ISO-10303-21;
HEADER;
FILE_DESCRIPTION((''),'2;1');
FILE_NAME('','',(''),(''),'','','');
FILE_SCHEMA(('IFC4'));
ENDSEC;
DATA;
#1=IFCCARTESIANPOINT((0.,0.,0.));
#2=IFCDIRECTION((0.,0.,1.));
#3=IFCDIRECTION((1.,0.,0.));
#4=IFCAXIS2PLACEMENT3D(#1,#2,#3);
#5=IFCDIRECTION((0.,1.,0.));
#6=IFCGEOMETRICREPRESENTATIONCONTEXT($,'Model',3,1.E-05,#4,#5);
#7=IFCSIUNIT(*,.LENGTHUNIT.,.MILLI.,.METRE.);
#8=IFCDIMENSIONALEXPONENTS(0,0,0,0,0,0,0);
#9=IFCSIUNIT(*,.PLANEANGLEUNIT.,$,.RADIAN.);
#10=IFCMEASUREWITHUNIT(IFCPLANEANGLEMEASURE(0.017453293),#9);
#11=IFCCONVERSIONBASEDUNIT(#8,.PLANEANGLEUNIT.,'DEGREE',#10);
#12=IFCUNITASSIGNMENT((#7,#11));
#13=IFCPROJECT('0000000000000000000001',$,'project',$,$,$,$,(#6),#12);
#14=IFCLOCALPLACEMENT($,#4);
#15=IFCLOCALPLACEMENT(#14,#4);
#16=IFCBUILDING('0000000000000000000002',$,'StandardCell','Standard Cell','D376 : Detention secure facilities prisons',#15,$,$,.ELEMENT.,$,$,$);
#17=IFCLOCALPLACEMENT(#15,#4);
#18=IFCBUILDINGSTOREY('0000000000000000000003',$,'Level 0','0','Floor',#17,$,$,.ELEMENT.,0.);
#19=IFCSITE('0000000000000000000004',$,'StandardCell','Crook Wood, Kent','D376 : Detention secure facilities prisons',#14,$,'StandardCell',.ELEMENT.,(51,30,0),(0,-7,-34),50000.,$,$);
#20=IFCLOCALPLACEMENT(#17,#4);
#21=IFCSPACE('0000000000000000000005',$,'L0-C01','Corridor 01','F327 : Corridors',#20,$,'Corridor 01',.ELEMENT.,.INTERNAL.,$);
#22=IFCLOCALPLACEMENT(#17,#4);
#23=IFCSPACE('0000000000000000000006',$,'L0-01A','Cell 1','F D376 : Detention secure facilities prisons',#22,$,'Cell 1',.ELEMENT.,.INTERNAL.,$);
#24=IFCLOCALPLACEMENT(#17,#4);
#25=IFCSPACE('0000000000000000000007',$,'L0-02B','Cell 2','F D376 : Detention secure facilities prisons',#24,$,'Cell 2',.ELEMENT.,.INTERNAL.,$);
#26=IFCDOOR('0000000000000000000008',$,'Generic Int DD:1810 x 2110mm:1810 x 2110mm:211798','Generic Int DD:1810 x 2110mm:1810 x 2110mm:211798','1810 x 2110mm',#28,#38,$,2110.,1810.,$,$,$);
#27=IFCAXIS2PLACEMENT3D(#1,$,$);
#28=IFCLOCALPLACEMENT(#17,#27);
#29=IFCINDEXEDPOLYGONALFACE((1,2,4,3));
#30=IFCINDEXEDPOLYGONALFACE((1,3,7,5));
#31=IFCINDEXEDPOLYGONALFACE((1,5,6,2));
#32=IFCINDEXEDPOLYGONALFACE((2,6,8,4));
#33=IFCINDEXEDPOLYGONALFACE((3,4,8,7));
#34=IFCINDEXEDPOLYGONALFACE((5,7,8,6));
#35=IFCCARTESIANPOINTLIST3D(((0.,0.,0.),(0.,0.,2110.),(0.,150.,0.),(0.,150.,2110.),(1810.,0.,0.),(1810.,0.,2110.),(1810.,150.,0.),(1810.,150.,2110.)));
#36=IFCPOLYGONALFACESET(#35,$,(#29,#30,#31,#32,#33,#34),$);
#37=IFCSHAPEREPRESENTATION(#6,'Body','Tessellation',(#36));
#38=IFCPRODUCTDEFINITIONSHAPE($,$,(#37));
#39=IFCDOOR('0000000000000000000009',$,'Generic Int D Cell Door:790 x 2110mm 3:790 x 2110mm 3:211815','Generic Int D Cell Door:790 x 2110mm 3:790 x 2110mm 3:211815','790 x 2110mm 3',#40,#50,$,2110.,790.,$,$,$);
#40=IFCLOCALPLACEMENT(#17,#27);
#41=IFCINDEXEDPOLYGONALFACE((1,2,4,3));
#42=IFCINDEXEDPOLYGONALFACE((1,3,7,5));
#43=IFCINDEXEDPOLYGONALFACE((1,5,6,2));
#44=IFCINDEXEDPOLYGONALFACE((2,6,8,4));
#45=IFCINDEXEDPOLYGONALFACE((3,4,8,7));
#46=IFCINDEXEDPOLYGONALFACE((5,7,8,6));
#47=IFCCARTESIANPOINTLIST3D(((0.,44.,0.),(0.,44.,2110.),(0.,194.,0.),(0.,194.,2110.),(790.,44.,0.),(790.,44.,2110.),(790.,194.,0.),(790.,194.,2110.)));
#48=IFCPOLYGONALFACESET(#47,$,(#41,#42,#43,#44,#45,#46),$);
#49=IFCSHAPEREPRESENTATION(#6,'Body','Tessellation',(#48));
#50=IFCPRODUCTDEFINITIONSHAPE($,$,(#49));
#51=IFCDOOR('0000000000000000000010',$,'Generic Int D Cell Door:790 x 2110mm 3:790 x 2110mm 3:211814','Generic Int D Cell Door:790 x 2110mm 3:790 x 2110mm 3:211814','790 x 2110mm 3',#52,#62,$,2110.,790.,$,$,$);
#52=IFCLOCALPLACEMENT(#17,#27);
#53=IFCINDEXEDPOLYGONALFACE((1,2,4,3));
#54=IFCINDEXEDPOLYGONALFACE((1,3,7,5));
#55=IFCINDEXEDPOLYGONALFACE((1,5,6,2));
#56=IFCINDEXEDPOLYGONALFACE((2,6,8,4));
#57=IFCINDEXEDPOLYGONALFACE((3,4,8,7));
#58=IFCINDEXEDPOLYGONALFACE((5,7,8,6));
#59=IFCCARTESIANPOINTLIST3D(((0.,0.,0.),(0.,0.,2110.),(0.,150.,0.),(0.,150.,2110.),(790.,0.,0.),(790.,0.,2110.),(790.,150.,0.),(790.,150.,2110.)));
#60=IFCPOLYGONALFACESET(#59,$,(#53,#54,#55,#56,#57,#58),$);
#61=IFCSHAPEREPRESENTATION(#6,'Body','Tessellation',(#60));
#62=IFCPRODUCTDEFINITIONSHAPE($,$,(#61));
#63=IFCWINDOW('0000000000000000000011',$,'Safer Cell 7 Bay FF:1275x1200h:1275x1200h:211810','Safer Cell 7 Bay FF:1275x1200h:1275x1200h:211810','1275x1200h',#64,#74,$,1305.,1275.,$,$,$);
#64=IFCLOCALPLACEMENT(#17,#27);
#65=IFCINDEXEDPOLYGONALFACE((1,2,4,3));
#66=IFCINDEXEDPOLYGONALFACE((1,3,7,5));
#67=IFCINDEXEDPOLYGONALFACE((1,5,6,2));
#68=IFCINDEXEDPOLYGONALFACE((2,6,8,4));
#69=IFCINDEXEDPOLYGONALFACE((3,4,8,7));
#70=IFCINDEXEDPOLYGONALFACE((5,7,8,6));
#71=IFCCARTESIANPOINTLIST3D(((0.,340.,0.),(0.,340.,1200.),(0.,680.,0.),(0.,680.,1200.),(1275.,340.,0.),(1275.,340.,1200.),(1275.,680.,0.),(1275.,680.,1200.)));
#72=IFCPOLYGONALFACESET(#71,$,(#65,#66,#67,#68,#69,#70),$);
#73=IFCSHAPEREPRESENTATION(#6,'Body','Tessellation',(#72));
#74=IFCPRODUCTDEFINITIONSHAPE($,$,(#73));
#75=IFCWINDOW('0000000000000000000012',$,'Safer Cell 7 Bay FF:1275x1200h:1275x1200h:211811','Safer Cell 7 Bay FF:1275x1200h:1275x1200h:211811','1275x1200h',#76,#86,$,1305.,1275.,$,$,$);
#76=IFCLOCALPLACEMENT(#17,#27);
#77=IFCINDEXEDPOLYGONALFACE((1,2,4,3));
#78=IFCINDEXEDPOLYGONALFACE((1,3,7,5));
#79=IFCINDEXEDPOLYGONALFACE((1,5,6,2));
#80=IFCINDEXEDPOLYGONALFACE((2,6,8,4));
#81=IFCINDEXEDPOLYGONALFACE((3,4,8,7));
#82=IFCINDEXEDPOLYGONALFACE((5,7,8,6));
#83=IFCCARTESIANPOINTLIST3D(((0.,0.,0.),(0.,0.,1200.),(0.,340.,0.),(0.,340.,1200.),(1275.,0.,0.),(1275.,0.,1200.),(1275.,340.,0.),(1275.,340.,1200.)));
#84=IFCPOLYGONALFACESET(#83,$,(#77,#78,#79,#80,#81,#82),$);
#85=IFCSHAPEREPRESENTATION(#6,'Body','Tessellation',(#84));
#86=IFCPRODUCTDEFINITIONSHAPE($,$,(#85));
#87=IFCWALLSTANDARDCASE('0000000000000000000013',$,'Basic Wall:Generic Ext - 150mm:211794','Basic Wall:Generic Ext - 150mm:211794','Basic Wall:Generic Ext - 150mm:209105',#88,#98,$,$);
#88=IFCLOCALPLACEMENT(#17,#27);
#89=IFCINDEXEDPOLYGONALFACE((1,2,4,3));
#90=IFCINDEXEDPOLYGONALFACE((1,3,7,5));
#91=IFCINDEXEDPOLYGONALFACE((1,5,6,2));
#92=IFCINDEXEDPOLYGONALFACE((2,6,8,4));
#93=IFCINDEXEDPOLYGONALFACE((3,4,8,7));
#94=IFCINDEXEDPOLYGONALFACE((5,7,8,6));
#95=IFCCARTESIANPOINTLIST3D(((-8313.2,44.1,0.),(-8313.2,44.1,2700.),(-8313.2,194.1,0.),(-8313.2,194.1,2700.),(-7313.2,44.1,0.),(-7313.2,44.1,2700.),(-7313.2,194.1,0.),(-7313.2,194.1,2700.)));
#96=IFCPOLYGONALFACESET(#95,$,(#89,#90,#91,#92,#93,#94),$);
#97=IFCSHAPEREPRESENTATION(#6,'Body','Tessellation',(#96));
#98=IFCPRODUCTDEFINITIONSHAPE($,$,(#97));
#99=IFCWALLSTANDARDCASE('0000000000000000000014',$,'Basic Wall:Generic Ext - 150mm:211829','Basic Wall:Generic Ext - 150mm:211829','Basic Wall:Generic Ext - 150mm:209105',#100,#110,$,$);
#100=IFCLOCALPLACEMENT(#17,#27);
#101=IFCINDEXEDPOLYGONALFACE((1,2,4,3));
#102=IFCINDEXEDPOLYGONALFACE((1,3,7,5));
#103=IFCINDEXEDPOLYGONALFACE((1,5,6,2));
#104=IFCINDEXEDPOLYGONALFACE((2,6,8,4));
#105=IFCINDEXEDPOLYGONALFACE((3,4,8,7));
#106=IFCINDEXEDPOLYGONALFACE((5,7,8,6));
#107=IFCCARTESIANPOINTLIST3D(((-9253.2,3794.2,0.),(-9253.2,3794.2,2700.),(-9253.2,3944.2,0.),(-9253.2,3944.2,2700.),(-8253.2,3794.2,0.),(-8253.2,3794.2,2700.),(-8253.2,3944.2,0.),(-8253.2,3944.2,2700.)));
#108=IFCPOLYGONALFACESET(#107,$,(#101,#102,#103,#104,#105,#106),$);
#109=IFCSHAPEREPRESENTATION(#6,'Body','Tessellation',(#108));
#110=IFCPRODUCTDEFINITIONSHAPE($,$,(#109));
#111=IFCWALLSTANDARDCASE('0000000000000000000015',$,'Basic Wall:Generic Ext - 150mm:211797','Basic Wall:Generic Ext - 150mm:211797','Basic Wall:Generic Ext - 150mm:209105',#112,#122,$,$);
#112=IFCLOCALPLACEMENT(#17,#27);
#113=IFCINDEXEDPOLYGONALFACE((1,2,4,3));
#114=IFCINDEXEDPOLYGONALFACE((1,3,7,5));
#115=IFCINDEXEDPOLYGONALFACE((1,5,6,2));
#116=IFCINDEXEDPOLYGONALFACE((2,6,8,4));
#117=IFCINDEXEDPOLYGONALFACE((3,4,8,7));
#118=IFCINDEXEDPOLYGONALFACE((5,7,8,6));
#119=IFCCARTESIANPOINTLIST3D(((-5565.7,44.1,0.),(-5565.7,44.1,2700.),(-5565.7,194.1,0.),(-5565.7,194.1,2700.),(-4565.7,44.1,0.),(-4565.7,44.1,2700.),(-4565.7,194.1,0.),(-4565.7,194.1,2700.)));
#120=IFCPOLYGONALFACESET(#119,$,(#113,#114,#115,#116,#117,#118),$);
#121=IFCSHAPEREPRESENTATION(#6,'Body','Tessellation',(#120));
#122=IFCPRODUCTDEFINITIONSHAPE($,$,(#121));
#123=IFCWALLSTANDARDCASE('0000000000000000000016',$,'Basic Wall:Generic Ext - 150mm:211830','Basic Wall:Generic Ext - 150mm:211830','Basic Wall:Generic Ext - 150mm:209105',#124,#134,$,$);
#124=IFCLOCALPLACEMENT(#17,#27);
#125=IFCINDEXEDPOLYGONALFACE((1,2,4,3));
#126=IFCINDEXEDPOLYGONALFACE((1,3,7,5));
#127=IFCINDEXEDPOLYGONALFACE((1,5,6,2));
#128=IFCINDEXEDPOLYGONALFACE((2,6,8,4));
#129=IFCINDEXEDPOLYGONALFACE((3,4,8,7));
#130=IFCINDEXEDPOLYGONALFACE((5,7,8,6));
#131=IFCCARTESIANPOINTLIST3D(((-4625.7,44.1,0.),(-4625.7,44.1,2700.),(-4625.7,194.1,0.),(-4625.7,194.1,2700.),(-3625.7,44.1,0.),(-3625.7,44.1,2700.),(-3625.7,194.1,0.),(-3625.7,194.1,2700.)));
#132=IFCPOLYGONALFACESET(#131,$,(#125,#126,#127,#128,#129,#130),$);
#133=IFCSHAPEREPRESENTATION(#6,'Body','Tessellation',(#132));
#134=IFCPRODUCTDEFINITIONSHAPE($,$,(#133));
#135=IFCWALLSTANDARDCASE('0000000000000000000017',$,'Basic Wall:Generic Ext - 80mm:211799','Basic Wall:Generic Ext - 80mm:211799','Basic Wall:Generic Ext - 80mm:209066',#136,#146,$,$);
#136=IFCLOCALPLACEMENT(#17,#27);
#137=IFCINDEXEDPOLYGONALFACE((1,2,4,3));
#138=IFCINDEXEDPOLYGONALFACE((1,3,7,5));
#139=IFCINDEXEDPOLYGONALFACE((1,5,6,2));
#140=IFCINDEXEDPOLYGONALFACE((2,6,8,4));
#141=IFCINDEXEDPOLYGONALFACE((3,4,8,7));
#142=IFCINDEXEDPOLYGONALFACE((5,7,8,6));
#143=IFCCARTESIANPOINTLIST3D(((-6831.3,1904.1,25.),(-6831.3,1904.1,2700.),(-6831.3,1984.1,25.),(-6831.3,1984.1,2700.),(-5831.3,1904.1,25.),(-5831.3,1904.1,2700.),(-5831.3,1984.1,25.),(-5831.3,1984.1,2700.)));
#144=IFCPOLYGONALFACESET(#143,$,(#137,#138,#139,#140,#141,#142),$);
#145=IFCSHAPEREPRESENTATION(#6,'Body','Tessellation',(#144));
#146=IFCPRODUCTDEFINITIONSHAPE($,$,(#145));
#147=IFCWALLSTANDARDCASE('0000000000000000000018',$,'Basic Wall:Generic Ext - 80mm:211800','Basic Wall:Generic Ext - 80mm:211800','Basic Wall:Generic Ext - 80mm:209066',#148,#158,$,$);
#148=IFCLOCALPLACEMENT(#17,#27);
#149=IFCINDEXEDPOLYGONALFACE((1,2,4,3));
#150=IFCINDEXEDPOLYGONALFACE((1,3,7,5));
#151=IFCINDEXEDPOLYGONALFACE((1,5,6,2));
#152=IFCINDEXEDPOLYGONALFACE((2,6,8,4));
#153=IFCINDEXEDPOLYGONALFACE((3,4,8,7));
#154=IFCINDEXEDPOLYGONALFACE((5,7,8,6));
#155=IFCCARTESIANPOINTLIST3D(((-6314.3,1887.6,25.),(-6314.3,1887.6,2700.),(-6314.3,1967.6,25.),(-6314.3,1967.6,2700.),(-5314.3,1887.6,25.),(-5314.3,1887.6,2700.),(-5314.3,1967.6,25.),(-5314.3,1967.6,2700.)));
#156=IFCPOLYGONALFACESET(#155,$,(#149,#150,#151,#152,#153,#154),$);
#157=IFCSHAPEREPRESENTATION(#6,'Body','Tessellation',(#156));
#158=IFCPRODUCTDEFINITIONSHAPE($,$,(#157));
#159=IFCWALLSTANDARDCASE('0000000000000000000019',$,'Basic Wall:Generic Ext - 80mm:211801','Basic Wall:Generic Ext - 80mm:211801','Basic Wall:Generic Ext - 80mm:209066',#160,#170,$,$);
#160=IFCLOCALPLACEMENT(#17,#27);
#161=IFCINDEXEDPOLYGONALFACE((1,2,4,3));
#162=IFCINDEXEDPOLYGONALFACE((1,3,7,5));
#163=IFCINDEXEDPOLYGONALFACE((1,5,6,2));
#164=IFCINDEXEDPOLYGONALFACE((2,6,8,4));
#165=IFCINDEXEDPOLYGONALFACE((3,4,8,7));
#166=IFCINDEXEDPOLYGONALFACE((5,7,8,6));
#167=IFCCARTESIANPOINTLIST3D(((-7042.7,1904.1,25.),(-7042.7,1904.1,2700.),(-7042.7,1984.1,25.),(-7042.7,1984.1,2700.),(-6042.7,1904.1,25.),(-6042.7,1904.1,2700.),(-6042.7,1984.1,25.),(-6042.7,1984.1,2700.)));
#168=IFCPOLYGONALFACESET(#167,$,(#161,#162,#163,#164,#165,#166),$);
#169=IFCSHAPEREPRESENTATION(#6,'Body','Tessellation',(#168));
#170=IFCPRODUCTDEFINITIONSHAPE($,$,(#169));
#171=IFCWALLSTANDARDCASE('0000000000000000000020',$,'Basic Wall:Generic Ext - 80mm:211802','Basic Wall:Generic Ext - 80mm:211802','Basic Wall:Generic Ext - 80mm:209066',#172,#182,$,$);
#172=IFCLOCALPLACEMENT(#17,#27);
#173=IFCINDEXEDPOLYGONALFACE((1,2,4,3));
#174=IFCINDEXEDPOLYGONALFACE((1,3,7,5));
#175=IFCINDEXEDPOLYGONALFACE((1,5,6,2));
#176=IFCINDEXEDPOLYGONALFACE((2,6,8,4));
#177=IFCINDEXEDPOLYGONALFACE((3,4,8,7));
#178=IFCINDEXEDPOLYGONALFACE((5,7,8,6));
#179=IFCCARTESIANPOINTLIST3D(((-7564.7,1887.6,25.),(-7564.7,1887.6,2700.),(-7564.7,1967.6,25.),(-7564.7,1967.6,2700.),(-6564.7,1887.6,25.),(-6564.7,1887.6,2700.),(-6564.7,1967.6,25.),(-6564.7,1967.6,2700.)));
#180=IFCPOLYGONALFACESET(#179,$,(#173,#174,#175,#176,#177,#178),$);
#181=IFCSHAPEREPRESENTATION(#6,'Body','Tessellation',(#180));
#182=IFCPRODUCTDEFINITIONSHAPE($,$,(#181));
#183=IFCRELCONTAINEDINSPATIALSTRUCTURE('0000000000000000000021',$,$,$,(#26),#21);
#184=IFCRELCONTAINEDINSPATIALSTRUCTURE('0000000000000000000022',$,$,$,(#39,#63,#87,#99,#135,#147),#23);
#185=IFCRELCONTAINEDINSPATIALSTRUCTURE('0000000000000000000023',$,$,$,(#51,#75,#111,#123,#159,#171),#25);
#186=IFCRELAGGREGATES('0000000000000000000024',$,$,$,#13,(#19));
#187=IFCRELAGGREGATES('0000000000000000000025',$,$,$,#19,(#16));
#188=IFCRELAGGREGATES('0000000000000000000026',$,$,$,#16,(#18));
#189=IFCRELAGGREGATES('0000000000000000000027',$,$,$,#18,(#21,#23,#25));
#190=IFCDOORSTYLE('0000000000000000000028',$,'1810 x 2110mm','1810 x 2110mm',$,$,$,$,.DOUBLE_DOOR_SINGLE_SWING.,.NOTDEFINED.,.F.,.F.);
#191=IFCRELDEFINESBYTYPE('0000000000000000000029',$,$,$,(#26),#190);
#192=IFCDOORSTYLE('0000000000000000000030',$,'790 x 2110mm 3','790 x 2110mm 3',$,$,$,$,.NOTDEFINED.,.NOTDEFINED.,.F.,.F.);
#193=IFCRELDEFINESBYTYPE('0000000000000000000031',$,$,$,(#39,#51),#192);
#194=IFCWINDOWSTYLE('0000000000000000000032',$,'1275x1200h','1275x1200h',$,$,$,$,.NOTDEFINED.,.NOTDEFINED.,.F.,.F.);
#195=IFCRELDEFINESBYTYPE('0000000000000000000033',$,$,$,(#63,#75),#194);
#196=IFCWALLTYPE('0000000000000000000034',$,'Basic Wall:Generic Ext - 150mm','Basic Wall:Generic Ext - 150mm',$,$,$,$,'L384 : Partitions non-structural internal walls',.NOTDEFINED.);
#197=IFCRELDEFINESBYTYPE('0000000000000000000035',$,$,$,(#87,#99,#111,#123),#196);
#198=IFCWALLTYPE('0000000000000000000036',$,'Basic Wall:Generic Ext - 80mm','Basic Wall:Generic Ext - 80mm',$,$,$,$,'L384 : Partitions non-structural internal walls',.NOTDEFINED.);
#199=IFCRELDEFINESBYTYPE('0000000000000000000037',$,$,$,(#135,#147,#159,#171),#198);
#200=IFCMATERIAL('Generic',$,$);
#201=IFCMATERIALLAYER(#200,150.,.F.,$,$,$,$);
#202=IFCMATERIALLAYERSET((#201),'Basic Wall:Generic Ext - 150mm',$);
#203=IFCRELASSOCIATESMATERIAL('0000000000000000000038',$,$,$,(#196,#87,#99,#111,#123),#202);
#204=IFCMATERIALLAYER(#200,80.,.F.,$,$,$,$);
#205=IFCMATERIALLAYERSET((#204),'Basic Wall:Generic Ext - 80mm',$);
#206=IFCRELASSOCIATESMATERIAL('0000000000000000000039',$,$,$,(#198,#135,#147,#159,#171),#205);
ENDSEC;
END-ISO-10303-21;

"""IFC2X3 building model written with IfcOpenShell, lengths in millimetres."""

from ifc_helpers import new_model, entity, si_unit, converted_unit, direction, frame, frame_2d, origin, origin_with_axes, place, context, project, spatial, rectangle, extrude, source, transform, mapped, material, layer, layer_set, layer_usage, type_object, type_shapes, element, save


model = new_model("IFC2X3")

# Units and contexts
model_context = context("Model", 3, precision=1e-05, world=origin_with_axes(), true_north=direction((0.0, 1.0, 0.0)))
ifc_project = project(units=[si_unit("LENGTHUNIT", "METRE", prefix="MILLI"), converted_unit("PLANEANGLEUNIT", "DEGREE", entity("IfcPlaneAngleMeasure", 0.017453293), si_unit("PLANEANGLEUNIT", "RADIAN"), dimensions=[0, 0, 0, 0, 0, 0, 0])], contexts=[model_context])

# Site, building, storey, space
site_placement = place(None, origin_with_axes())
site = spatial("IfcSite", under=ifc_project, at=site_placement, Name="StandardCell", Description="Crook Wood, Kent", ObjectType="D376 : Detention secure facilities prisons", LongName="StandardCell", CompositionType="ELEMENT", RefLatitude=(51, 30, 0), RefLongitude=(0, -7, -34), RefElevation=50000.0)
building_placement = place(site_placement, origin_with_axes())
building = spatial("IfcBuilding", under=site, at=building_placement, Name="StandardCell", Description="Standard Cell", ObjectType="D376 : Detention secure facilities prisons", CompositionType="ELEMENT")
storey_placement = place(building_placement, origin_with_axes())
storey = spatial("IfcBuildingStorey", under=building, at=storey_placement, Name="Level 0", Description="0", ObjectType="Floor", CompositionType="ELEMENT", Elevation=0.0)
space_1_placement = place(storey_placement, origin_with_axes())
space_1 = spatial("IfcSpace", under=storey, at=space_1_placement, Name="L0-C01", Description="Corridor 01", ObjectType="F327 : Corridors", LongName="Corridor 01", CompositionType="ELEMENT", InteriorOrExteriorSpace="INTERNAL")

# Door
door_style_1 = type_object("IfcDoorStyle", Name="1810 x 2110mm", Description="1810 x 2110mm", ConstructionType="NOTDEFINED", OperationType="DOUBLE_DOOR_SINGLE_SWING", ParameterTakesPrecedence=False, Sizeable=False)
shared_shape_1 = source(origin(), model_context, "Body", "SweptSolid", [
    extrude(rectangle(XDim=1810.0, YDim=150.0, at=frame_2d((905.0, 75.0), x_axis=(1.0, 0.0))), origin_with_axes(), (0.0, 0.0, 1.0), 2110.0),
])
type_shapes(door_style_1, [shared_shape_1])
door_1_placement = place(space_1_placement, origin_with_axes())
element("IfcDoor", 1, at=door_1_placement, inside=space_1, type_object=door_style_1, Name="Generic Int DD:1810 x 2110mm:1810 x 2110mm:211798", Description="Generic Int DD:1810 x 2110mm:1810 x 2110mm:211798", ObjectType="1810 x 2110mm", OverallHeight=2110.0, OverallWidth=1810.0, context=model_context, shape_type="MappedRepresentation", body=[
    mapped(shared_shape_1, transform((0.0, 0.0, 0.0))),
])

# Shared definitions
space_2_placement = place(storey_placement, origin_with_axes())
space_2 = spatial("IfcSpace", under=storey, at=space_2_placement, Name="L0-01A", Description="Cell 1", ObjectType="F D376 : Detention secure facilities prisons", LongName="Cell 1", CompositionType="ELEMENT", InteriorOrExteriorSpace="INTERNAL")

# Door
door_style_2 = type_object("IfcDoorStyle", Name="790 x 2110mm 3", Description="790 x 2110mm 3", ConstructionType="NOTDEFINED", OperationType="NOTDEFINED", ParameterTakesPrecedence=False, Sizeable=False)
shared_shape_2 = source(origin(), model_context, "Body", "SweptSolid", [
    extrude(rectangle(XDim=790.0, YDim=150.0, at=frame_2d((395.0, 75.0), x_axis=(1.0, 0.0))), origin_with_axes(), (0.0, 0.0, 1.0), 2110.0),
])
type_shapes(door_style_2, [shared_shape_2])
door_2_placement = place(space_2_placement, frame((0.0, 44.0, 0.0), z_axis=(0.0, 0.0, 1.0), x_axis=(1.0, 0.0, 0.0)))
element("IfcDoor", 2, at=door_2_placement, inside=space_2, type_object=door_style_2, Name="Generic Int D Cell Door:790 x 2110mm 3:790 x 2110mm 3:211815", Description="Generic Int D Cell Door:790 x 2110mm 3:790 x 2110mm 3:211815", ObjectType="790 x 2110mm 3", OverallHeight=2110.0, OverallWidth=790.0, context=model_context, shape_type="MappedRepresentation", body=[
    mapped(shared_shape_2, transform((0.0, 0.0, 0.0))),
])

# Shared definitions
space_3_placement = place(storey_placement, origin_with_axes())
space_3 = spatial("IfcSpace", under=storey, at=space_3_placement, Name="L0-02B", Description="Cell 2", ObjectType="F D376 : Detention secure facilities prisons", LongName="Cell 2", CompositionType="ELEMENT", InteriorOrExteriorSpace="INTERNAL")

# Door
door_3_placement = place(space_3_placement, origin_with_axes())
element("IfcDoor", 3, at=door_3_placement, inside=space_3, type_object=door_style_2, Name="Generic Int D Cell Door:790 x 2110mm 3:790 x 2110mm 3:211814", Description="Generic Int D Cell Door:790 x 2110mm 3:790 x 2110mm 3:211814", ObjectType="790 x 2110mm 3", OverallHeight=2110.0, OverallWidth=790.0, context=model_context, shape_type="MappedRepresentation", body=[
    mapped(shared_shape_2, transform((0.0, 0.0, 0.0))),
])

# Windows
window_style = type_object("IfcWindowStyle", Name="1275x1200h", Description="1275x1200h", ConstructionType="NOTDEFINED", OperationType="NOTDEFINED", ParameterTakesPrecedence=False, Sizeable=False)
shared_shape_3 = source(origin(), model_context, "Body", "SweptSolid", [
    extrude(rectangle(XDim=1275.0, YDim=340.0, at=frame_2d((637.5, 170.0), x_axis=(1.0, 0.0))), origin_with_axes(), (0.0, 0.0, 1.0), 1200.0),
])
type_shapes(window_style, [shared_shape_3])
window_1_placement = place(space_2_placement, frame((0.0, 340.0, 0.0), z_axis=(0.0, 0.0, 1.0), x_axis=(1.0, 0.0, 0.0)))
element("IfcWindow", 4, at=window_1_placement, inside=space_2, type_object=window_style, Name="Safer Cell 7 Bay FF:1275x1200h:1275x1200h:211810", Description="Safer Cell 7 Bay FF:1275x1200h:1275x1200h:211810", ObjectType="1275x1200h", OverallHeight=1305.0, OverallWidth=1275.0, context=model_context, shape_type="MappedRepresentation", body=[
    mapped(shared_shape_3, transform((0.0, 0.0, 0.0))),
])
window_2_placement = place(space_3_placement, origin_with_axes())
element("IfcWindow", 5, at=window_2_placement, inside=space_3, type_object=window_style, Name="Safer Cell 7 Bay FF:1275x1200h:1275x1200h:211811", Description="Safer Cell 7 Bay FF:1275x1200h:1275x1200h:211811", ObjectType="1275x1200h", OverallHeight=1305.0, OverallWidth=1275.0, context=model_context, shape_type="MappedRepresentation", body=[
    mapped(shared_shape_3, transform((0.0, 0.0, 0.0))),
])

# Walls
ifc_material = material(Name="Generic")
ifc_layer_1 = layer(ifc_material, 150.0, ventilated=False)
ifc_layer_set_1 = layer_set([ifc_layer_1], Name="Basic Wall:Generic Ext - 150mm")
ifc_layer_usage_1 = layer_usage(ifc_layer_set_1, "AXIS3", "POSITIVE", 0.0)
wall_type_1 = type_object("IfcWallType", Name="Basic Wall:Generic Ext - 150mm", Description="Basic Wall:Generic Ext - 150mm", ElementType="L384 : Partitions non-structural internal walls", PredefinedType="NOTDEFINED", material=ifc_layer_set_1)
shared_shape_4 = source(origin(), model_context, "Body", "SweptSolid", [
    extrude(rectangle(XDim=1000.0, YDim=150.0, at=frame_2d((500.0, 75.0), x_axis=(1.0, 0.0))), origin_with_axes(), (0.0, 0.0, 1.0), 2700.0),
])
type_shapes(wall_type_1, [shared_shape_4])
for number, where, z_axis, x_axis, name, description in (
    (6, (-8313.2, 44.1, 0.0), (0.0, 0.0, 1.0), (1.0, 0.0, 0.0), "Basic Wall:Generic Ext - 150mm:211794", "Basic Wall:Generic Ext - 150mm:211794"),
    (7, (-9253.2, 3794.2, 0.0), (0.0, 0.0, 1.0), (1.0, 0.0, 0.0), "Basic Wall:Generic Ext - 150mm:211829", "Basic Wall:Generic Ext - 150mm:211829"),
):
    element("IfcWallStandardCase", number, at=place(space_2_placement, frame(where, z_axis=z_axis, x_axis=x_axis)), inside=space_2, type_object=wall_type_1, material=ifc_layer_usage_1, Name=name, Description=description, ObjectType="Basic Wall:Generic Ext - 150mm:209105", context=model_context, shape_type="MappedRepresentation", body=[
        mapped(shared_shape_4, transform((0.0, 0.0, 0.0))),
    ])
for number, where, z_axis, x_axis, name, description in (
    (8, (-5565.7, 44.1, 0.0), (0.0, 0.0, 1.0), (1.0, 0.0, 0.0), "Basic Wall:Generic Ext - 150mm:211797", "Basic Wall:Generic Ext - 150mm:211797"),
    (9, (-4625.7, 44.1, 0.0), (0.0, 0.0, 1.0), (1.0, 0.0, 0.0), "Basic Wall:Generic Ext - 150mm:211830", "Basic Wall:Generic Ext - 150mm:211830"),
):
    element("IfcWallStandardCase", number, at=place(space_3_placement, frame(where, z_axis=z_axis, x_axis=x_axis)), inside=space_3, type_object=wall_type_1, material=ifc_layer_usage_1, Name=name, Description=description, ObjectType="Basic Wall:Generic Ext - 150mm:209105", context=model_context, shape_type="MappedRepresentation", body=[
        mapped(shared_shape_4, transform((0.0, 0.0, 0.0))),
    ])
ifc_layer_2 = layer(ifc_material, 80.0, ventilated=False)
ifc_layer_set_2 = layer_set([ifc_layer_2], Name="Basic Wall:Generic Ext - 80mm")
ifc_layer_usage_2 = layer_usage(ifc_layer_set_2, "AXIS3", "POSITIVE", 0.0)
wall_type_2 = type_object("IfcWallType", Name="Basic Wall:Generic Ext - 80mm", Description="Basic Wall:Generic Ext - 80mm", ElementType="L384 : Partitions non-structural internal walls", PredefinedType="NOTDEFINED", material=ifc_layer_set_2)
shared_shape_5 = source(origin(), model_context, "Body", "SweptSolid", [
    extrude(rectangle(XDim=1000.0, YDim=80.0, at=frame_2d((500.0, 40.0), x_axis=(1.0, 0.0))), origin_with_axes(), (0.0, 0.0, 1.0), 2675.0),
])
type_shapes(wall_type_2, [shared_shape_5])
for number, where, z_axis, x_axis, name, description in (
    (10, (-6831.3, 1904.1, 25.0), (0.0, 0.0, 1.0), (1.0, 0.0, 0.0), "Basic Wall:Generic Ext - 80mm:211799", "Basic Wall:Generic Ext - 80mm:211799"),
    (11, (-6314.3, 1887.6, 25.0), (0.0, 0.0, 1.0), (1.0, 0.0, 0.0), "Basic Wall:Generic Ext - 80mm:211800", "Basic Wall:Generic Ext - 80mm:211800"),
):
    element("IfcWallStandardCase", number, at=place(space_2_placement, frame(where, z_axis=z_axis, x_axis=x_axis)), inside=space_2, type_object=wall_type_2, material=ifc_layer_usage_2, Name=name, Description=description, ObjectType="Basic Wall:Generic Ext - 80mm:209066", context=model_context, shape_type="MappedRepresentation", body=[
        mapped(shared_shape_5, transform((0.0, 0.0, 0.0))),
    ])
for number, where, z_axis, x_axis, name, description in (
    (12, (-7042.7, 1904.1, 25.0), (0.0, 0.0, 1.0), (1.0, 0.0, 0.0), "Basic Wall:Generic Ext - 80mm:211801", "Basic Wall:Generic Ext - 80mm:211801"),
    (13, (-7564.7, 1887.6, 25.0), (0.0, 0.0, 1.0), (1.0, 0.0, 0.0), "Basic Wall:Generic Ext - 80mm:211802", "Basic Wall:Generic Ext - 80mm:211802"),
):
    element("IfcWallStandardCase", number, at=place(space_3_placement, frame(where, z_axis=z_axis, x_axis=x_axis)), inside=space_3, type_object=wall_type_2, material=ifc_layer_usage_2, Name=name, Description=description, ObjectType="Basic Wall:Generic Ext - 80mm:209066", context=model_context, shape_type="MappedRepresentation", body=[
        mapped(shared_shape_5, transform((0.0, 0.0, 0.0))),
    ])

save(model, "model.ifc")
